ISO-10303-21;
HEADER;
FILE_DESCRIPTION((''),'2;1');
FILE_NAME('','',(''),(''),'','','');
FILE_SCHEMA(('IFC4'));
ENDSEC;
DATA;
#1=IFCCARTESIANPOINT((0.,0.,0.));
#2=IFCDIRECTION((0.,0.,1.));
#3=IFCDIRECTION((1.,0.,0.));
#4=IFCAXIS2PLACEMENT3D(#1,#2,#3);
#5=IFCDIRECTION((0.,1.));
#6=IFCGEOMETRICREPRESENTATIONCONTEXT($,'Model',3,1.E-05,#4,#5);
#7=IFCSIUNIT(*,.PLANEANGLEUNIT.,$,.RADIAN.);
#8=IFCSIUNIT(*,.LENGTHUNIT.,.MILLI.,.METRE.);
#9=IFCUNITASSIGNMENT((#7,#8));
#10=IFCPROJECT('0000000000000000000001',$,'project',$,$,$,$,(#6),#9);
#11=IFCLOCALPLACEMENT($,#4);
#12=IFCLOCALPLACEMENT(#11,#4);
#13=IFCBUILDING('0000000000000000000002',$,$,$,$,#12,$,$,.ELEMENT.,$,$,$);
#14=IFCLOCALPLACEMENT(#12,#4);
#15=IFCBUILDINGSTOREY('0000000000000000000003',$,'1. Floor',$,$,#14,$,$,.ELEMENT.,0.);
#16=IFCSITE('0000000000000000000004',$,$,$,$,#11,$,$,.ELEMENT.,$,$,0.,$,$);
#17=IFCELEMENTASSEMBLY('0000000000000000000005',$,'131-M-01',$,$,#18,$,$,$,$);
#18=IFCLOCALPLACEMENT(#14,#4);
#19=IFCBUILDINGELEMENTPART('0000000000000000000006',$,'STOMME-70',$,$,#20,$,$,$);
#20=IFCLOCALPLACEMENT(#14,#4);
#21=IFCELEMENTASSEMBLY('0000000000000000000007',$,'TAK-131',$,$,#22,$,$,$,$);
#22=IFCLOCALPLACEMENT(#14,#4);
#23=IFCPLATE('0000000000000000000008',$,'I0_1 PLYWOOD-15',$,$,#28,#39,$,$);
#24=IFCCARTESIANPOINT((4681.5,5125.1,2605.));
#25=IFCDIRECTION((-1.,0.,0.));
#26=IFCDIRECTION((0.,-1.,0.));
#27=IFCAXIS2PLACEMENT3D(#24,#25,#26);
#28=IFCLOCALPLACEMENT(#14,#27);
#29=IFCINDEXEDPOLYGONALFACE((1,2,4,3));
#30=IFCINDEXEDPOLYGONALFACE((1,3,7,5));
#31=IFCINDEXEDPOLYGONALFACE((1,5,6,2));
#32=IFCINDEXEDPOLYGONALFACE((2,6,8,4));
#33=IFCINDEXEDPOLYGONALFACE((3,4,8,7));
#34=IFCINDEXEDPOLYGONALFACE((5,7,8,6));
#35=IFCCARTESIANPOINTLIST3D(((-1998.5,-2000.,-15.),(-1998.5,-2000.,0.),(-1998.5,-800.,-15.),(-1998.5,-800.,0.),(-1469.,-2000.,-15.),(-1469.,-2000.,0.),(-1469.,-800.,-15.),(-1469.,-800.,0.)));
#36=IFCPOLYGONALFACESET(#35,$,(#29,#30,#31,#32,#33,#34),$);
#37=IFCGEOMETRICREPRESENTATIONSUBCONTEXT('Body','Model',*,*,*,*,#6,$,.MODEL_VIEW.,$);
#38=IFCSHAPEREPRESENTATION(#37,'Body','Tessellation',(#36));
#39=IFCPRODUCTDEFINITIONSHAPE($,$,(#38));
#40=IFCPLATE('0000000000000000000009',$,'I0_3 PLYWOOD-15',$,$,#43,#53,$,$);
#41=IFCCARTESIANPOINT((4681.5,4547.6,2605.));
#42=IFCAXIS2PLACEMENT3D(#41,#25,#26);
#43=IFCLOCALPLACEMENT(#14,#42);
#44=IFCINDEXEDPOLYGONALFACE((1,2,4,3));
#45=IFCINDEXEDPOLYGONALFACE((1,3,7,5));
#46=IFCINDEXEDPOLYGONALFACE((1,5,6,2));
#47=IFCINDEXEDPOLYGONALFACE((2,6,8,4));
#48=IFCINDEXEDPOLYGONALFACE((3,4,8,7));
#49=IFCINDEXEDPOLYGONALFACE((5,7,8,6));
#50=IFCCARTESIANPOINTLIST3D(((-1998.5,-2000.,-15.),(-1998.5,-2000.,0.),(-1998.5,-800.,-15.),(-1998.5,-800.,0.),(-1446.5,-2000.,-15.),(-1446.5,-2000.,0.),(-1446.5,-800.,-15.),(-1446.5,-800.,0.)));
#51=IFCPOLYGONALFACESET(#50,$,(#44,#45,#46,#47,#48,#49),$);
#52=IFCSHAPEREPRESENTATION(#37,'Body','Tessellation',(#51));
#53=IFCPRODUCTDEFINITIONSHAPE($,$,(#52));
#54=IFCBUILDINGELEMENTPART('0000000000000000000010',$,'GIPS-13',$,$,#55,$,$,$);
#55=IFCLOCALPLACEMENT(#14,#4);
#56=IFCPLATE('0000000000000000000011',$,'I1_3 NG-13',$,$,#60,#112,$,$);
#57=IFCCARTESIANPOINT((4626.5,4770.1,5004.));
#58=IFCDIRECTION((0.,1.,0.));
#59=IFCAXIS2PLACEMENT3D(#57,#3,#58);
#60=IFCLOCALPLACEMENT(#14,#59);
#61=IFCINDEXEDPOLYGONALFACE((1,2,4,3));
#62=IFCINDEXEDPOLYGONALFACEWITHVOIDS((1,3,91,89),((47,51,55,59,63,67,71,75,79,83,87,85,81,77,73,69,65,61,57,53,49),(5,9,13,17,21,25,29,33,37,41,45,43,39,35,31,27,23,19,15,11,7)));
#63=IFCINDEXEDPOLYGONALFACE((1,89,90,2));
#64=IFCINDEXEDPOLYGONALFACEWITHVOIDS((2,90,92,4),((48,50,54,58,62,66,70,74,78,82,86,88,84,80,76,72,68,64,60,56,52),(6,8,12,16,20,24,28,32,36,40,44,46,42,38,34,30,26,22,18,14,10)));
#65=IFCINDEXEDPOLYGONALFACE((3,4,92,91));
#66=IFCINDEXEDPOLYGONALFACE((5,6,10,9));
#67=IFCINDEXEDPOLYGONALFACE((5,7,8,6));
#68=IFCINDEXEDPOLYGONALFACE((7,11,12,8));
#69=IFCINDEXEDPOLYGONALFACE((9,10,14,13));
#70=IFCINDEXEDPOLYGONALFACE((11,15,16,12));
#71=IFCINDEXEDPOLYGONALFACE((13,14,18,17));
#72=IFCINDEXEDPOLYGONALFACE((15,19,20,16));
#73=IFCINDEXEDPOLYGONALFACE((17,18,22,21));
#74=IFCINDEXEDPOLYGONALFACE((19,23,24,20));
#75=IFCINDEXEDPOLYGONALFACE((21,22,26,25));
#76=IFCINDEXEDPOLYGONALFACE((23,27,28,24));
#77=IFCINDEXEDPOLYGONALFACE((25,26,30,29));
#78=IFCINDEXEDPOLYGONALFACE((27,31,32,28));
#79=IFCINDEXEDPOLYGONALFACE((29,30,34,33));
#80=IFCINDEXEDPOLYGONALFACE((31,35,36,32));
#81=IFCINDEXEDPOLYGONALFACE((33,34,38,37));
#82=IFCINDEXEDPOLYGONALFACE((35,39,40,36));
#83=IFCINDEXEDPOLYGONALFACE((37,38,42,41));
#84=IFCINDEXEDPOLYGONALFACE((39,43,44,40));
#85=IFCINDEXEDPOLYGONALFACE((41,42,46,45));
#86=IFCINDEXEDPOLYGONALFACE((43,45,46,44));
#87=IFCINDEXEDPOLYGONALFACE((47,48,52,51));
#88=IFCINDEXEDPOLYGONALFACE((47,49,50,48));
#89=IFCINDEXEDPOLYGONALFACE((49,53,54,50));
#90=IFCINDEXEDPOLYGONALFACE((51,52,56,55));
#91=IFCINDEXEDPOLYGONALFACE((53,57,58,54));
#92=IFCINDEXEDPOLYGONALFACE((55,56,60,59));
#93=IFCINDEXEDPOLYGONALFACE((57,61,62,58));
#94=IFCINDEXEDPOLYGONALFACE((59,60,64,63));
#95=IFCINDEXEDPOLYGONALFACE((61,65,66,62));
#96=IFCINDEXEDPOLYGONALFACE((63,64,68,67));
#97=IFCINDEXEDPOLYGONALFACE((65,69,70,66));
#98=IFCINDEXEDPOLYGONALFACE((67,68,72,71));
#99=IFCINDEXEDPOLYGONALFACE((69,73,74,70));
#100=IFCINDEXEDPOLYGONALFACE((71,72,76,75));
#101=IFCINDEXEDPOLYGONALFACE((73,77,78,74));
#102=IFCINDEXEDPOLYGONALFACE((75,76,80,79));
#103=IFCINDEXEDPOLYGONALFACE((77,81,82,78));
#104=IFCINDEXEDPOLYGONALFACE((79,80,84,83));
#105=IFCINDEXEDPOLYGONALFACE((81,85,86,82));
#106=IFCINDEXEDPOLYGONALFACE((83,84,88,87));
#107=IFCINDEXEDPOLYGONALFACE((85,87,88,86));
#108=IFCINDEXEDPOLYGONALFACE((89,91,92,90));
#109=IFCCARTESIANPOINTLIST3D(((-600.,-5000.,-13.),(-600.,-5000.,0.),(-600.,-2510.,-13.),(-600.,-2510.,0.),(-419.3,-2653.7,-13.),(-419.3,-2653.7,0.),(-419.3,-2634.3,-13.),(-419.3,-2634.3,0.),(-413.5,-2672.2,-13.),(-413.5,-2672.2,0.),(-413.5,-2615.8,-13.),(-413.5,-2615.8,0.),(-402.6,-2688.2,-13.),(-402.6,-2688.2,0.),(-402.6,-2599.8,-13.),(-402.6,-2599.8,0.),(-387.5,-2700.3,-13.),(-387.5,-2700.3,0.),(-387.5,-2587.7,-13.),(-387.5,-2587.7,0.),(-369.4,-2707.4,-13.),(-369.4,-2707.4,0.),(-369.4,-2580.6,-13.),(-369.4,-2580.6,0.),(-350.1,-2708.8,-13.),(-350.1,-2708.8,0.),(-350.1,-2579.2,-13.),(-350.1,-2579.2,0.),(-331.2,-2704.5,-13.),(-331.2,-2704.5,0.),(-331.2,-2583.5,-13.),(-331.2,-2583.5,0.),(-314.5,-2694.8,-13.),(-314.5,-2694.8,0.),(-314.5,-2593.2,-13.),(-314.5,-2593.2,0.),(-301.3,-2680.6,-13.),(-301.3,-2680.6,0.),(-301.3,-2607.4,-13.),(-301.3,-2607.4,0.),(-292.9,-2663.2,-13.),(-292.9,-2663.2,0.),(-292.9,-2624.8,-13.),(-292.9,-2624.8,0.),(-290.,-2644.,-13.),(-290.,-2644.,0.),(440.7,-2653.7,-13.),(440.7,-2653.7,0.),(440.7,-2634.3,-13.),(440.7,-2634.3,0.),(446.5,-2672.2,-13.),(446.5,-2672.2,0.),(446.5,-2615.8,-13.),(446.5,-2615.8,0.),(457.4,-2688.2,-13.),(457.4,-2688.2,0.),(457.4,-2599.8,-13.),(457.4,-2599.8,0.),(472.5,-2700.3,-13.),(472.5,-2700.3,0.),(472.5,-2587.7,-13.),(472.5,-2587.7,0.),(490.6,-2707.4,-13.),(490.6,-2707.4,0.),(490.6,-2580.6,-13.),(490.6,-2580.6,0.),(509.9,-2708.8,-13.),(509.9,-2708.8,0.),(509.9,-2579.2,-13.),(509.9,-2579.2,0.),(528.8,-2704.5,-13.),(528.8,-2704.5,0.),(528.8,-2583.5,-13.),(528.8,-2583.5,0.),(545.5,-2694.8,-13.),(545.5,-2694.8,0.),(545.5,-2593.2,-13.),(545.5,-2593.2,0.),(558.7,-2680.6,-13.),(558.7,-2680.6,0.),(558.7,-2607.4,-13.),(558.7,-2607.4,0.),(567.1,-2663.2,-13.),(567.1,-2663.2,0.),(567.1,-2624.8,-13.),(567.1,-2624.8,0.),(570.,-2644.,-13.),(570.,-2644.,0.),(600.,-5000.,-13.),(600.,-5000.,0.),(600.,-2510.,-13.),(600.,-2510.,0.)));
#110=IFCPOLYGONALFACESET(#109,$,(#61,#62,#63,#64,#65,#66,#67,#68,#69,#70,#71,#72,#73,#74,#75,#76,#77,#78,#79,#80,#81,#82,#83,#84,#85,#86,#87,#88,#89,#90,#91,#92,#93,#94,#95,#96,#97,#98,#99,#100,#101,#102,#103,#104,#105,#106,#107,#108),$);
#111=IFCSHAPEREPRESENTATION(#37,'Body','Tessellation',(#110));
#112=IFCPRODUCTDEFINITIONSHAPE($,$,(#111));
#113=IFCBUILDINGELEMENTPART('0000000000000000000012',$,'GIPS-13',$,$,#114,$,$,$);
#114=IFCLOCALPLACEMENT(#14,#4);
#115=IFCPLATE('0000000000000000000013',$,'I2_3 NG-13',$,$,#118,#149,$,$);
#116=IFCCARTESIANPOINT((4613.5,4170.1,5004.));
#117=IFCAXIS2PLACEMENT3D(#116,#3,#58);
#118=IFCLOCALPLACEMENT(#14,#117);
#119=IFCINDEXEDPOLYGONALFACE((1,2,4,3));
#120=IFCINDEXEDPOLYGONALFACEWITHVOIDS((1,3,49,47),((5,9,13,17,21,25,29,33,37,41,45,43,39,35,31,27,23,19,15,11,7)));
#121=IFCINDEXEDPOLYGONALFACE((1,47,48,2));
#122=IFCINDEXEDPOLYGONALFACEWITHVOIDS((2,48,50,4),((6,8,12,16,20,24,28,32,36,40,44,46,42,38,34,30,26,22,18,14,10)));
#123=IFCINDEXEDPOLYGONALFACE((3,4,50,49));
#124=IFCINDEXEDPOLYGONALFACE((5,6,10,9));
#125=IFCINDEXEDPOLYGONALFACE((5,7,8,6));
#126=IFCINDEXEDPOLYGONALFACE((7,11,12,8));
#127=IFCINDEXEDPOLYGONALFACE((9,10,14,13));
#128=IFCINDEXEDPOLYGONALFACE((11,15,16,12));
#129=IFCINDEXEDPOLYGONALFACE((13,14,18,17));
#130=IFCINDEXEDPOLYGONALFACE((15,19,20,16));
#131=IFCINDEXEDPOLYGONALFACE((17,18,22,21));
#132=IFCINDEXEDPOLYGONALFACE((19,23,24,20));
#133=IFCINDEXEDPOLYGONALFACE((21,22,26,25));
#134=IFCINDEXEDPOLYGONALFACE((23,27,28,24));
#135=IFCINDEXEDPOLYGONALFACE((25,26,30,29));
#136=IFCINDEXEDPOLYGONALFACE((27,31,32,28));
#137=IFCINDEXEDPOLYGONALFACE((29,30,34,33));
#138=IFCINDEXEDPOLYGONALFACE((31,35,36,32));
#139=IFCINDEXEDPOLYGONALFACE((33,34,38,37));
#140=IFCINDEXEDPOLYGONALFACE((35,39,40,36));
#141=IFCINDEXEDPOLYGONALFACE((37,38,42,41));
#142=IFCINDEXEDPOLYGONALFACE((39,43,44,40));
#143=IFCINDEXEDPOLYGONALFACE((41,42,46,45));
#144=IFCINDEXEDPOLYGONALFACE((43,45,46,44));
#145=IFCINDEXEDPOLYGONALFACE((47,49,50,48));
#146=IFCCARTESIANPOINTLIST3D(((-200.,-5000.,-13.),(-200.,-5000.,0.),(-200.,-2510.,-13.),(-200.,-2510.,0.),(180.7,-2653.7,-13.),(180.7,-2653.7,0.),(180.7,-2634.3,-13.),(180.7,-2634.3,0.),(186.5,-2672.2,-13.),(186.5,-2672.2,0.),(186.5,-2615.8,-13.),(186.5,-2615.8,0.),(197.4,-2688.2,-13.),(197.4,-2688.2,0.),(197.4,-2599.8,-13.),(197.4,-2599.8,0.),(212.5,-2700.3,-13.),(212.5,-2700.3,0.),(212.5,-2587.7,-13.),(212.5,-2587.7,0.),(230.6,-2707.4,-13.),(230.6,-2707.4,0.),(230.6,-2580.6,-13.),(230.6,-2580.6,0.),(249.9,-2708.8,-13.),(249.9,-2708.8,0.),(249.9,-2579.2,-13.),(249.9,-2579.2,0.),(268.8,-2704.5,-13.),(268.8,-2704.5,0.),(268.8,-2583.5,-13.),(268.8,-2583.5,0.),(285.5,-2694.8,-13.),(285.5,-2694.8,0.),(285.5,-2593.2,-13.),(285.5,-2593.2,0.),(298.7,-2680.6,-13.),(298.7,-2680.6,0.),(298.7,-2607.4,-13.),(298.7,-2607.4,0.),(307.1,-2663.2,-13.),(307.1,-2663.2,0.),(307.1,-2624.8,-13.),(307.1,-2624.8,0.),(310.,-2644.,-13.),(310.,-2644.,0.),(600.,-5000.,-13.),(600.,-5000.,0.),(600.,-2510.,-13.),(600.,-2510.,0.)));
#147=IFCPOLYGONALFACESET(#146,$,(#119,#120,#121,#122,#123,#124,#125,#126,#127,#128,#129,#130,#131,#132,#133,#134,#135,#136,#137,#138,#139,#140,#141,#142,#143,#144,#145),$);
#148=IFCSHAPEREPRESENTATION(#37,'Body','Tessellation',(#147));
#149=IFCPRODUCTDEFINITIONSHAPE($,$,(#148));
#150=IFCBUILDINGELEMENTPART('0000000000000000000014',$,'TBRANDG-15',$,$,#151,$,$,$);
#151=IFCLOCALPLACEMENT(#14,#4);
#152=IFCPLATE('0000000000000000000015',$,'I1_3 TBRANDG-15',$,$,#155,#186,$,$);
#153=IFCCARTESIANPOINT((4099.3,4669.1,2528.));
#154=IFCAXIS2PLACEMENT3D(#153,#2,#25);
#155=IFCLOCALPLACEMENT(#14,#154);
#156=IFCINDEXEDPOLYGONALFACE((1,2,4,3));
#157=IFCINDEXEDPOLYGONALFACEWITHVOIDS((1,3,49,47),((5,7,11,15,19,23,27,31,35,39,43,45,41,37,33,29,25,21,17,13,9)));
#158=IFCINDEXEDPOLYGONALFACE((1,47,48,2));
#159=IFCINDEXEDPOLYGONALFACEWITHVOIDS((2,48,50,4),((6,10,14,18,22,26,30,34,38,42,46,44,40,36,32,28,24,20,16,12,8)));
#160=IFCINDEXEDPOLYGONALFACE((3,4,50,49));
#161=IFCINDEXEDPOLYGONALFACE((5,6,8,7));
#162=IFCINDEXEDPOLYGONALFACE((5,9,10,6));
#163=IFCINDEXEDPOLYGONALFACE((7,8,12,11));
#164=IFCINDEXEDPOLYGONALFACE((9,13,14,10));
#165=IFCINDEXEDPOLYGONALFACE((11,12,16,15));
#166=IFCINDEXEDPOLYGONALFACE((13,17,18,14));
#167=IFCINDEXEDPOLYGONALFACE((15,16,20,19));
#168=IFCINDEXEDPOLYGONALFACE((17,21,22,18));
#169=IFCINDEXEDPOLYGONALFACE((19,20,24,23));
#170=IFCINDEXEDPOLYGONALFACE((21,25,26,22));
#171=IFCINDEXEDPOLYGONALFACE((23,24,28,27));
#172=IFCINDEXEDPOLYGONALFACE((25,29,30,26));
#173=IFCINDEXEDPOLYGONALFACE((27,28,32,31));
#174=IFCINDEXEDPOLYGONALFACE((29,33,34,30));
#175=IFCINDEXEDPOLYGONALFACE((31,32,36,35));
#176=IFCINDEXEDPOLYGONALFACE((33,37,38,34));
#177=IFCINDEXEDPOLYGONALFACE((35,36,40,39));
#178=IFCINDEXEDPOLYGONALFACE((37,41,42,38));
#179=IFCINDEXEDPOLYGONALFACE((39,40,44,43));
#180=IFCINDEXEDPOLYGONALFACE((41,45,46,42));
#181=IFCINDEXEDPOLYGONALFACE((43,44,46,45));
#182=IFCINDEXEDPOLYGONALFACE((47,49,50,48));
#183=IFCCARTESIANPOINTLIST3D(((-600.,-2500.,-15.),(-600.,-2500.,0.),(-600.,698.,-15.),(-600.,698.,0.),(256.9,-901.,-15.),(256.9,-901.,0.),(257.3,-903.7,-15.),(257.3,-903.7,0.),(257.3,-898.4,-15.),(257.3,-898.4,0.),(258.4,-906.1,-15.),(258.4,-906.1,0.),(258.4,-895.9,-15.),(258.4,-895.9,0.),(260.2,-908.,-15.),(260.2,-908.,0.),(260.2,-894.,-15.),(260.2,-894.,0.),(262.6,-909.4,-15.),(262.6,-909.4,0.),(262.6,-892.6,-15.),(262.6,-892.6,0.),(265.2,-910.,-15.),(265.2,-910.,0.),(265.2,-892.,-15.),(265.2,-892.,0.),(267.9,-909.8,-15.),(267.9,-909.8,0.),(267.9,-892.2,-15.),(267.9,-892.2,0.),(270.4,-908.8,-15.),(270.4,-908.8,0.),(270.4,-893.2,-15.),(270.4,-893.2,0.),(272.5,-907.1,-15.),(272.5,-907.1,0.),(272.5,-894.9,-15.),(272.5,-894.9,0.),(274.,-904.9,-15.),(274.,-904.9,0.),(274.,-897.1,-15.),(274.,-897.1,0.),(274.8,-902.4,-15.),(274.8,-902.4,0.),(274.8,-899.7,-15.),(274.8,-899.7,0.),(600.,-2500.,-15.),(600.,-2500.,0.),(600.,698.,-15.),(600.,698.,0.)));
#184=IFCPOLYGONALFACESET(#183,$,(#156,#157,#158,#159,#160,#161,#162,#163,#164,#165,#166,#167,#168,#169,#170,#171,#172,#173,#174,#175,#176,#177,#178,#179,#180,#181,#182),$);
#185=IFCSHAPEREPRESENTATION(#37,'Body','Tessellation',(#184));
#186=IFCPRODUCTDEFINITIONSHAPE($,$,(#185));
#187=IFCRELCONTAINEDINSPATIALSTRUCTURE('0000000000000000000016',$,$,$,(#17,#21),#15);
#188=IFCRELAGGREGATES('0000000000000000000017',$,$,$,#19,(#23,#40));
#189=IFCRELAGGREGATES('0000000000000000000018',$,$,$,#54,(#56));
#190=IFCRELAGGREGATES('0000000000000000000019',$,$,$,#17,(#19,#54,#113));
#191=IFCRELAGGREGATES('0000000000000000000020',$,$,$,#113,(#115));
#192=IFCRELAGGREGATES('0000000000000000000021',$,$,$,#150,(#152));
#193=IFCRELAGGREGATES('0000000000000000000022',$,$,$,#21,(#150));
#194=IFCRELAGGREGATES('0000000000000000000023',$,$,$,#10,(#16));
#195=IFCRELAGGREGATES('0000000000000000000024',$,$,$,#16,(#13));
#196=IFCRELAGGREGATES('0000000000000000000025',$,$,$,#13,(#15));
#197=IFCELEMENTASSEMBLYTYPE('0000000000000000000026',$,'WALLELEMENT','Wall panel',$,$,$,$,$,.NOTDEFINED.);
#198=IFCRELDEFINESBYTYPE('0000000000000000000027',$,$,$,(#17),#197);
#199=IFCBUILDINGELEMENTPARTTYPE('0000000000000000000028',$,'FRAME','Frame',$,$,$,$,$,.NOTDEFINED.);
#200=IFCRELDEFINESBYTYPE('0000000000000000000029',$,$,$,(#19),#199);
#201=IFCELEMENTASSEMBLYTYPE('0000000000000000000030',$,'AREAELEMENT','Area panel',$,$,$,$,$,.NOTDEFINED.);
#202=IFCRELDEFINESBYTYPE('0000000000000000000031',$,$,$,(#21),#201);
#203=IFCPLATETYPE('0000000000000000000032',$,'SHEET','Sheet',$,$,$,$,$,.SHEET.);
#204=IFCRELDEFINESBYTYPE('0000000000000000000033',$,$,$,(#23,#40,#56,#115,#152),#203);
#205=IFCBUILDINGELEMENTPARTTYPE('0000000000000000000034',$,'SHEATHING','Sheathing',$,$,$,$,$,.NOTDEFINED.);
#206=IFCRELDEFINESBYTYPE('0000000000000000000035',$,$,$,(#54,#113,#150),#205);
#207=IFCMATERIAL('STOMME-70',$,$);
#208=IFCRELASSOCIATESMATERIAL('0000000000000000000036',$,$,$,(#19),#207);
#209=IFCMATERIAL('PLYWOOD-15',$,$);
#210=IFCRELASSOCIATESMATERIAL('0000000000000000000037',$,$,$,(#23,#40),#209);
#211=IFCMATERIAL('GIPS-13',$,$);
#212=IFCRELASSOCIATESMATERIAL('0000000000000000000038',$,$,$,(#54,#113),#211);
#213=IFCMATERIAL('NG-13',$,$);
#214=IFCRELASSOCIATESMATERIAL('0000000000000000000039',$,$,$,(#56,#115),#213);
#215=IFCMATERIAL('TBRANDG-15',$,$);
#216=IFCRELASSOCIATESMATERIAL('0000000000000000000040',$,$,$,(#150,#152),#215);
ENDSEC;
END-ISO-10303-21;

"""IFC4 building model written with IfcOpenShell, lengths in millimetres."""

from ifc_helpers import new_model, si_unit, direction, frame, origin_with_axes, origin_2d_with_axis, place, context, subcontext, project, spatial, rectangle, circle, extrude, boolean, material, type_object, element, aggregate, save


model = new_model("IFC4")

# Units and contexts
model_context = context("Model", 3, precision=1e-05, world=origin_with_axes(), true_north=direction((0.0, 1.0)))
body_context = subcontext(model_context, "Body", "Model", "MODEL_VIEW")
ifc_project = project(units=[si_unit("PLANEANGLEUNIT", "RADIAN"), si_unit("LENGTHUNIT", "METRE", prefix="MILLI")], contexts=[model_context])

# Site, building, storey
site_placement = place(None, origin_with_axes())
site = spatial("IfcSite", under=ifc_project, at=site_placement, CompositionType="ELEMENT", RefElevation=0.0)
building_placement = place(site_placement, origin_with_axes())
building = spatial("IfcBuilding", under=site, at=building_placement, CompositionType="ELEMENT")
storey_placement = place(building_placement, origin_with_axes())
storey = spatial("IfcBuildingStorey", under=building, at=storey_placement, Name="1. Floor", CompositionType="ELEMENT", Elevation=0.0)

# Element assembly, building element part
element_assembly_type_1 = type_object("IfcElementAssemblyType", Name="WALLELEMENT", Description="Wall panel", PredefinedType="NOTDEFINED")
assembly_1_placement = place(storey_placement, origin_with_axes())
assembly_1 = element("IfcElementAssembly", 1, at=assembly_1_placement, inside=storey, type_object=element_assembly_type_1, Name="131-M-01")
ifc_material_1 = material(Name="STOMME-70")
building_element_part_type_1 = type_object("IfcBuildingElementPartType", Name="FRAME", Description="Frame", PredefinedType="NOTDEFINED")
building_element_part_1_placement = place(storey_placement, origin_with_axes())
building_element_part_1 = element("IfcBuildingElementPart", 2, at=building_element_part_1_placement, type_object=building_element_part_type_1, material=ifc_material_1, Name="STOMME-70")

# Element assembly
element_assembly_type_2 = type_object("IfcElementAssemblyType", Name="AREAELEMENT", Description="Area panel", PredefinedType="NOTDEFINED")
assembly_2_placement = place(storey_placement, origin_with_axes())
assembly_2 = element("IfcElementAssembly", 3, at=assembly_2_placement, inside=storey, type_object=element_assembly_type_2, Name="TAK-131")

# Shared definitions
ifc_material_2 = material(Name="GIPS-13")
building_element_part_type_2 = type_object("IfcBuildingElementPartType", Name="SHEATHING", Description="Sheathing", PredefinedType="NOTDEFINED")
ifc_material_3 = material(Name="NG-13")
plate_type_1 = type_object("IfcPlateType", Name="SHEET", Description="Sheet", PredefinedType="SHEET")

# Plates
ifc_material_4 = material(Name="PLYWOOD-15")
plate_1_placement = place(storey_placement, frame((4681.5, 5125.1, 2605.0), z_axis=(-1.0, 0.0, 0.0), x_axis=(0.0, -1.0, 0.0)))
plate_1 = element("IfcPlate", 4, at=plate_1_placement, type_object=plate_type_1, material=ifc_material_4, Name="I0_1 PLYWOOD-15", context=body_context, shape_type="SweptSolid", body=[
    extrude(rectangle(XDim=15.0, YDim=529.5, at=origin_2d_with_axis()), frame((-1733.8, -2000.0, -7.5), z_axis=(0.0, 1.0, 0.0), x_axis=(0.0, 0.0, 1.0)), (0.0, 0.0, 1.0), 1200.0),
])
plate_2_placement = place(storey_placement, frame((4681.5, 4547.6, 2605.0), z_axis=(-1.0, 0.0, 0.0), x_axis=(0.0, -1.0, 0.0)))
plate_2 = element("IfcPlate", 5, at=plate_2_placement, type_object=plate_type_1, material=ifc_material_4, Name="I0_3 PLYWOOD-15", context=body_context, shape_type="SweptSolid", body=[
    extrude(rectangle(XDim=15.0, YDim=552.0, at=origin_2d_with_axis()), frame((-1722.5, -2000.0, -7.5), z_axis=(0.0, 1.0, 0.0), x_axis=(0.0, 0.0, 1.0)), (0.0, 0.0, 1.0), 1200.0),
])
aggregate(building_element_part_1, [plate_1, plate_2])

# Building element part, plate
building_element_part_2_placement = place(storey_placement, origin_with_axes())
building_element_part_2 = element("IfcBuildingElementPart", 6, at=building_element_part_2_placement, type_object=building_element_part_type_2, material=ifc_material_2, Name="GIPS-13")
plate_3_placement = place(storey_placement, frame((4626.5, 4770.1, 5004.0), z_axis=(1.0, 0.0, 0.0), x_axis=(0.0, 1.0, 0.0)))
plate_3 = element("IfcPlate", 7, at=plate_3_placement, type_object=plate_type_1, material=ifc_material_3, Name="I1_3 NG-13", context=body_context, shape_type="CSG", body=[
    boolean("DIFFERENCE", boolean("DIFFERENCE", extrude(rectangle(XDim=13.0, YDim=1200.0, at=origin_2d_with_axis()), frame((0.0, -5000.0, -6.5), z_axis=(0.0, 1.0, 0.0), x_axis=(0.0, 0.0, 1.0)), (0.0, 0.0, 1.0), 2490.0), extrude(circle(Radius=65.0, at=origin_2d_with_axis()), frame((505.0, -2644.0, -27.0), z_axis=(0.0, 0.0, -1.0), x_axis=(1.0, 0.0, 0.0)), (0.0, 0.0, -1.0), 65.0)), extrude(circle(Radius=65.0, at=origin_2d_with_axis()), frame((-355.0, -2644.0, -27.0), z_axis=(0.0, 0.0, -1.0), x_axis=(1.0, 0.0, 0.0)), (0.0, 0.0, -1.0), 65.0)),
])
aggregate(building_element_part_2, [plate_3])

# Building element part
building_element_part_3_placement = place(storey_placement, origin_with_axes())
building_element_part_3 = element("IfcBuildingElementPart", 8, at=building_element_part_3_placement, type_object=building_element_part_type_2, material=ifc_material_2, Name="GIPS-13")
aggregate(assembly_1, [building_element_part_1, building_element_part_2, building_element_part_3])

# Plate
plate_4_placement = place(storey_placement, frame((4613.5, 4170.1, 5004.0), z_axis=(1.0, 0.0, 0.0), x_axis=(0.0, 1.0, 0.0)))
plate_4 = element("IfcPlate", 9, at=plate_4_placement, type_object=plate_type_1, material=ifc_material_3, Name="I2_3 NG-13", context=body_context, shape_type="CSG", body=[
    boolean("DIFFERENCE", extrude(rectangle(XDim=13.0, YDim=800.0, at=origin_2d_with_axis()), frame((200.0, -5000.0, -6.5), z_axis=(0.0, 1.0, 0.0), x_axis=(0.0, 0.0, 1.0)), (0.0, 0.0, 1.0), 2490.0), extrude(circle(Radius=65.0, at=origin_2d_with_axis()), frame((245.0, -2644.0, -14.0), z_axis=(0.0, 0.0, -1.0), x_axis=(1.0, 0.0, 0.0)), (0.0, 0.0, -1.0), 65.0)),
])
aggregate(building_element_part_3, [plate_4])

# Building element part, plate
ifc_material_5 = material(Name="TBRANDG-15")
building_element_part_4_placement = place(storey_placement, origin_with_axes())
building_element_part_4 = element("IfcBuildingElementPart", 10, at=building_element_part_4_placement, type_object=building_element_part_type_2, material=ifc_material_5, Name="TBRANDG-15")
plate_5_placement = place(storey_placement, frame((4099.3, 4669.1, 2528.0), z_axis=(0.0, 0.0, 1.0), x_axis=(-1.0, 0.0, 0.0)))
plate_5 = element("IfcPlate", 11, at=plate_5_placement, type_object=plate_type_1, material=ifc_material_5, Name="I1_3 TBRANDG-15", context=body_context, shape_type="CSG", body=[
    boolean("DIFFERENCE", boolean("DIFFERENCE", extrude(rectangle(XDim=15.0, YDim=1200.0, at=origin_2d_with_axis()), frame((0.0, -2500.0, -7.5), z_axis=(0.0, 1.0, 0.0), x_axis=(0.0, 0.0, 1.0)), (0.0, 0.0, 1.0), 3198.0), extrude(circle(Radius=9.0, at=origin_2d_with_axis()), frame((265.9, -901.0, 10.0), z_axis=(0.0, 0.0, 1.0), x_axis=(-1.0, 0.0, 0.0)), (0.0, 0.0, -1.0), 50.0)), extrude(circle(Radius=9.0, at=origin_2d_with_axis()), frame((265.9, -901.0, 10.0), z_axis=(0.0, 0.0, 1.0), x_axis=(-1.0, 0.0, 0.0)), (0.0, 0.0, -1.0), 50.0)),
])
aggregate(building_element_part_4, [plate_5])

aggregate(assembly_2, [building_element_part_4])

save(model, "model.ifc")
